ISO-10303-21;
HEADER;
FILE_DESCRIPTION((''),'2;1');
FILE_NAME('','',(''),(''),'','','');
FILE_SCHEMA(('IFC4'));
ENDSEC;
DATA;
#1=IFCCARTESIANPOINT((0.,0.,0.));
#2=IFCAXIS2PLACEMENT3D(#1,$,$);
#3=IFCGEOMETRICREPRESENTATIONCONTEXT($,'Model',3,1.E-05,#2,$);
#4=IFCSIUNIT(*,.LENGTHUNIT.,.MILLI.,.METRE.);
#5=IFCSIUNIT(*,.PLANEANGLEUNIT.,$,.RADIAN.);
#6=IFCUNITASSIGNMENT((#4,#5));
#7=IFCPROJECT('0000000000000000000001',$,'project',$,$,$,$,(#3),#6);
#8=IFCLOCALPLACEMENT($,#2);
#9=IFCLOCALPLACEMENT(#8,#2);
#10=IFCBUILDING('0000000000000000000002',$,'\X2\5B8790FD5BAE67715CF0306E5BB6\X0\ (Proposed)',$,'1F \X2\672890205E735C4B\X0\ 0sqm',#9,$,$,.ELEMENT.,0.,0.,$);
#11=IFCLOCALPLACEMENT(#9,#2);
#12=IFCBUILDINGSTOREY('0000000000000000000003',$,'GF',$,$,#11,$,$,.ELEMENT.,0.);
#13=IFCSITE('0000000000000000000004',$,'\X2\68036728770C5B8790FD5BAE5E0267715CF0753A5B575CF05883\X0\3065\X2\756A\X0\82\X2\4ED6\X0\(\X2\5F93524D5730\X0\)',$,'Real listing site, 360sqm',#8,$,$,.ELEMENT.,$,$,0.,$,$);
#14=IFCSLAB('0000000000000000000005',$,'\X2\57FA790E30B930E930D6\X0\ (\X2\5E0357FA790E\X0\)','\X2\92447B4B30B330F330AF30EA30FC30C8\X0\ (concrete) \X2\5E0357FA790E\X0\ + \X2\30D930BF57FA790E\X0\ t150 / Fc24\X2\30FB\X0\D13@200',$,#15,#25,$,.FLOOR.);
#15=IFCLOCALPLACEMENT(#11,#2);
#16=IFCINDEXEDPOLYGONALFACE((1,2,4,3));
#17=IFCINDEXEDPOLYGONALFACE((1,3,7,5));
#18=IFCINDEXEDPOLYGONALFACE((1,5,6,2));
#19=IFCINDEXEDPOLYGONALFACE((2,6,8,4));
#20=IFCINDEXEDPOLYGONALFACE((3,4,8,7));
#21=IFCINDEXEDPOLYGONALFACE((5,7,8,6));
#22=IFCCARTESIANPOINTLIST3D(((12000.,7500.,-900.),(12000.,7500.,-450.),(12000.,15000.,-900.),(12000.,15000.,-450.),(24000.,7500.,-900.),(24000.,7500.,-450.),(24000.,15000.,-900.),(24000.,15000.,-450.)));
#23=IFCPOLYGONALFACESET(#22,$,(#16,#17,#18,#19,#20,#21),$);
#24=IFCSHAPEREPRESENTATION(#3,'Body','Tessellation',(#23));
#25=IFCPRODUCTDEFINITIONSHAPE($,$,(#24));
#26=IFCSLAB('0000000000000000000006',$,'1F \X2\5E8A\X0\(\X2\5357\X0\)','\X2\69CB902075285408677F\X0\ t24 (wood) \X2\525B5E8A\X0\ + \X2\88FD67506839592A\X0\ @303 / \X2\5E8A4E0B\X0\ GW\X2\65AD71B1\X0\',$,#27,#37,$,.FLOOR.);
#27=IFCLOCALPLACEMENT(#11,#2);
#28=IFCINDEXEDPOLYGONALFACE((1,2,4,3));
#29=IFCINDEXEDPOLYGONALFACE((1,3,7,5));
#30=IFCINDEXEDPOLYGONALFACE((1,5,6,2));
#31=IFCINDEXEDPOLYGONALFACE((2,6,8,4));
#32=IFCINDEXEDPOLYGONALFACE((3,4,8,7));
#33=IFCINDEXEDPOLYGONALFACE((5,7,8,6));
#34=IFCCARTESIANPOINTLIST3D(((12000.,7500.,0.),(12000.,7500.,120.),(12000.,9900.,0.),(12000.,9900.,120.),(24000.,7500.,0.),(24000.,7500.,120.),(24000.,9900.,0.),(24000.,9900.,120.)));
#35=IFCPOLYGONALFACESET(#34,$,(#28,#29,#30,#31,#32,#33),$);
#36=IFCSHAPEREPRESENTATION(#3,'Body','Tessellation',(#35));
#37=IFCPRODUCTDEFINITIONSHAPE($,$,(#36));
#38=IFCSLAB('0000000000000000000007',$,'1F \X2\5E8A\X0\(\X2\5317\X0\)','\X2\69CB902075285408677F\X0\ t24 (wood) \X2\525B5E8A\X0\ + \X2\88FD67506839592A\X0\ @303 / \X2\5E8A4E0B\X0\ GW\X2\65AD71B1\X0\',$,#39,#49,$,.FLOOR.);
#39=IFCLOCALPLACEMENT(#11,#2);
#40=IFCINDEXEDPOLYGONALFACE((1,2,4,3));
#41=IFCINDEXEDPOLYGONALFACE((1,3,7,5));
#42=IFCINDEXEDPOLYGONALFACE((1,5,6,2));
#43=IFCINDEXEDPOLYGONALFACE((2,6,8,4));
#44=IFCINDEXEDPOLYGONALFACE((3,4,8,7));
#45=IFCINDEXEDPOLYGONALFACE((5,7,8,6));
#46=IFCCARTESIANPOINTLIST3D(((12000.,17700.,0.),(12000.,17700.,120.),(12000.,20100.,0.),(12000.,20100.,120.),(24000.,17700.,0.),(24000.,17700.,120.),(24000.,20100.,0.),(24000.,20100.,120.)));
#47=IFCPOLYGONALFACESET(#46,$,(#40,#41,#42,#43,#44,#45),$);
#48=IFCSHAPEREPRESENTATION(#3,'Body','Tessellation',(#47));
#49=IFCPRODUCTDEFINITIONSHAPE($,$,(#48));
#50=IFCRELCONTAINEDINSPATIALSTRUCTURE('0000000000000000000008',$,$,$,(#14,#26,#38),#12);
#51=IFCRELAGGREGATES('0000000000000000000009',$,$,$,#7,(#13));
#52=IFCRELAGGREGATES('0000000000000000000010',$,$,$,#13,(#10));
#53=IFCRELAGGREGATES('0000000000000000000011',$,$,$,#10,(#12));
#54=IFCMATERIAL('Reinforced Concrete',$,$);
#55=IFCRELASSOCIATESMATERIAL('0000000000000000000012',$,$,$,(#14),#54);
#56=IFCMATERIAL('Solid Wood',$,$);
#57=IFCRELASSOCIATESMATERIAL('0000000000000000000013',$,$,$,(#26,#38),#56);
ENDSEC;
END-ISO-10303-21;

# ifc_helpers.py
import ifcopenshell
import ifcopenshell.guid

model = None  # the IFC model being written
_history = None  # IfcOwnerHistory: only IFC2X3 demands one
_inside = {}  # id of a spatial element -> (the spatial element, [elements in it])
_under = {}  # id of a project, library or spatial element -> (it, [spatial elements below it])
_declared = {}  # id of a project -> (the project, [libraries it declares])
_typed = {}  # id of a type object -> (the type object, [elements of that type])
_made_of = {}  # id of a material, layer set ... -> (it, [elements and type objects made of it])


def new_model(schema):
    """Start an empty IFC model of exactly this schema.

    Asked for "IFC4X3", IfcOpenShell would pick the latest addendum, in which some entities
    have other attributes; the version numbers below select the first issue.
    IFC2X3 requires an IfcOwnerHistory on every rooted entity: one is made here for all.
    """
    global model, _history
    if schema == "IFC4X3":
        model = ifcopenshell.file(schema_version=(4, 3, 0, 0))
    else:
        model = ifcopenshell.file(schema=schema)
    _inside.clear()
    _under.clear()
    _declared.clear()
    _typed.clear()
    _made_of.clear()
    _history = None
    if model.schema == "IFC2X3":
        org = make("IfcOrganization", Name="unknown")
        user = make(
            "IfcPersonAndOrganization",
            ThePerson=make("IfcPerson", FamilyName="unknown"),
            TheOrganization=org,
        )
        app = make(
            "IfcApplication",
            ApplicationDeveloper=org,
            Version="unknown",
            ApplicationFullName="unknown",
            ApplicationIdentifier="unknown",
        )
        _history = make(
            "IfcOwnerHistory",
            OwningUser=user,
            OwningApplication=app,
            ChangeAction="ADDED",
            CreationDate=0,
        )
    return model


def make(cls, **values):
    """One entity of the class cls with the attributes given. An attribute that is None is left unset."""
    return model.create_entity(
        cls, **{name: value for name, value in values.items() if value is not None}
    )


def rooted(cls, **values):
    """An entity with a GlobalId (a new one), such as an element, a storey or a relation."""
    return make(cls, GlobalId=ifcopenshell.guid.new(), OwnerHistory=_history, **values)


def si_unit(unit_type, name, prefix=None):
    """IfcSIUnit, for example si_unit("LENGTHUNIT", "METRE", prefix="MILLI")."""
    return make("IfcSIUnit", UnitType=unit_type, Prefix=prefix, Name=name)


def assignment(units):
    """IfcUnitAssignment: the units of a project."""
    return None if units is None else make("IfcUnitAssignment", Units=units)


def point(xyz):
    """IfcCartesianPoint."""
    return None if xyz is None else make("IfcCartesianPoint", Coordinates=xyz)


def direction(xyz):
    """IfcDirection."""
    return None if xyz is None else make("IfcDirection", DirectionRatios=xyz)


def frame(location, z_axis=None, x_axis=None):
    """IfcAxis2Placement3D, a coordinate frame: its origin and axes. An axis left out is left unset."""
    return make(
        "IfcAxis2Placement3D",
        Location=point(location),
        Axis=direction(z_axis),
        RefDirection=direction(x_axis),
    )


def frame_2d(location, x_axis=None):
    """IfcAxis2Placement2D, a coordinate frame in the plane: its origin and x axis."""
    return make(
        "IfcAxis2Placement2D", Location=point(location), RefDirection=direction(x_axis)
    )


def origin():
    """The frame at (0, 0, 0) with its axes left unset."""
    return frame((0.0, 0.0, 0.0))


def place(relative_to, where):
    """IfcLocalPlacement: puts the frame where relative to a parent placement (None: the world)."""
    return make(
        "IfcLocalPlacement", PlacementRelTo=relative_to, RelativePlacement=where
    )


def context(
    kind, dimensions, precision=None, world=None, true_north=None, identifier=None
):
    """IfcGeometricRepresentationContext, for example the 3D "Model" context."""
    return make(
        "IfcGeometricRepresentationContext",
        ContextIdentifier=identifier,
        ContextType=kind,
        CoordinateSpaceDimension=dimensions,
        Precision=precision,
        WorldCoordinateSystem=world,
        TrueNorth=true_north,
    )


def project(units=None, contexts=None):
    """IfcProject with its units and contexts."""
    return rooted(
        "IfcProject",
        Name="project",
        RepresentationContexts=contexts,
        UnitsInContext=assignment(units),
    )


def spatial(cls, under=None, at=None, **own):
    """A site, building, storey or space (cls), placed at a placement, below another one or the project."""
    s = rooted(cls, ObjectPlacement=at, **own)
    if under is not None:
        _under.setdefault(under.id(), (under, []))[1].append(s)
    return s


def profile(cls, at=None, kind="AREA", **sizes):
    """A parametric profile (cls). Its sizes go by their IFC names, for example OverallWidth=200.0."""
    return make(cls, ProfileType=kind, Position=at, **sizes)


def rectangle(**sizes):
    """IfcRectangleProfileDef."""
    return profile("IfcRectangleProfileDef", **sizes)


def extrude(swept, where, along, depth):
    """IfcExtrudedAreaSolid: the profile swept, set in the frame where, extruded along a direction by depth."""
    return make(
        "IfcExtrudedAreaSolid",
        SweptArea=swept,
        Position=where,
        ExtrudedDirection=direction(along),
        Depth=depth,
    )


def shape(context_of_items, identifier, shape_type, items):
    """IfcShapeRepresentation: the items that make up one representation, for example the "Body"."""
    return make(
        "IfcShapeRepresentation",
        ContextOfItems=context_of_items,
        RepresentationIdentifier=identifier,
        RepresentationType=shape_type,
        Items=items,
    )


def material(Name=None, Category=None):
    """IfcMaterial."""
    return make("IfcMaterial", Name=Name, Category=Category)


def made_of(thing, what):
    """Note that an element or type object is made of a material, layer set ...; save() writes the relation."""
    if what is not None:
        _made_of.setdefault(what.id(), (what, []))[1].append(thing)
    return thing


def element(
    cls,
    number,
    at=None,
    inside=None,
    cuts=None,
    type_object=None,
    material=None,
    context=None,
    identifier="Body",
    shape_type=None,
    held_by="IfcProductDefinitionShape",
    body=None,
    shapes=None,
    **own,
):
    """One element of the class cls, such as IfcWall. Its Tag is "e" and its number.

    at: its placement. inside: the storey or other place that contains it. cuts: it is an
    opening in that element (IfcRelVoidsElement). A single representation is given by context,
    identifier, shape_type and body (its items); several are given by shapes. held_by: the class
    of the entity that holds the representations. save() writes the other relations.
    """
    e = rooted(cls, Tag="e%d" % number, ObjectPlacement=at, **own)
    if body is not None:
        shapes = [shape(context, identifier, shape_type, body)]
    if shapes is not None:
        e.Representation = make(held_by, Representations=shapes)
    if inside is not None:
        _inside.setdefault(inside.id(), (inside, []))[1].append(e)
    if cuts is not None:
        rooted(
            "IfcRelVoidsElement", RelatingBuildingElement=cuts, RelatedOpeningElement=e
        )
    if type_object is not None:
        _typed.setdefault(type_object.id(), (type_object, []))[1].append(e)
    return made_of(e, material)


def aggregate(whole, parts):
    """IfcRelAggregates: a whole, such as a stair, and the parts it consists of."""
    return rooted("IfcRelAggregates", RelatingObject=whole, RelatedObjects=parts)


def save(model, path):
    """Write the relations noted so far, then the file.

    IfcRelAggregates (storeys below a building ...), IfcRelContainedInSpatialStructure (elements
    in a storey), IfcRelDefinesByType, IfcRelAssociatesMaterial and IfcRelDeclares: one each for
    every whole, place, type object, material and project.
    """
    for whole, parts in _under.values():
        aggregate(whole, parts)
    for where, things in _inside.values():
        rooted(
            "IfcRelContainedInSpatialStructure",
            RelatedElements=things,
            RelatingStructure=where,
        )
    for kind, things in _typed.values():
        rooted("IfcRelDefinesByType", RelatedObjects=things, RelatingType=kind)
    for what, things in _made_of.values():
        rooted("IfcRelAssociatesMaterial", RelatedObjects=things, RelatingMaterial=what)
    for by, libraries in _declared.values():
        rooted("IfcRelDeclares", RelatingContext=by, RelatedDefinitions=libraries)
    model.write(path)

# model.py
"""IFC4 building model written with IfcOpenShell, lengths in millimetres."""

from ifc_helpers import new_model, si_unit, frame, frame_2d, origin, place, context, project, spatial, rectangle, extrude, material, element, save


model = new_model("IFC4")

# Units and contexts
model_context = context("Model", 3, precision=1e-05, world=origin())
ifc_project = project(units=[si_unit("LENGTHUNIT", "METRE", prefix="MILLI"), si_unit("PLANEANGLEUNIT", "RADIAN")], contexts=[model_context])

# Site, building, storey
site_placement = place(None, origin())
site = spatial("IfcSite", under=ifc_project, at=site_placement, Name="栃木県宇都宮市東峰町字峰境3065番82他(従前地)", ObjectType="Real listing site, 360sqm", CompositionType="ELEMENT", RefElevation=0.0)
building_placement = place(site_placement, origin())
building = spatial("IfcBuilding", under=site, at=building_placement, Name="宇都宮東峰の家 (Proposed)", ObjectType="1F 木造平屋 0sqm", CompositionType="ELEMENT", ElevationOfRefHeight=0.0, ElevationOfTerrain=0.0)
storey_placement = place(building_placement, origin())
storey = spatial("IfcBuildingStorey", under=building, at=storey_placement, Name="GF", CompositionType="ELEMENT", Elevation=0.0)

# Slabs
ifc_material_1 = material(Name="Reinforced Concrete")
slab_1_placement = place(storey_placement, frame((6000.0, 3750.0, -450.0)))
element("IfcSlab", 1, at=slab_1_placement, inside=storey, material=ifc_material_1, Name="基礎スラブ (布基礎)", Description="鉄筋コンクリート (concrete) 布基礎 + ベタ基礎 t150 / Fc24・D13@200", PredefinedType="FLOOR", context=model_context, shape_type="SweptSolid", body=[
    extrude(rectangle(XDim=12000.0, YDim=7500.0, at=frame_2d((6000.0, 3750.0))), frame((6000.0, 3750.0, -450.0)), (0.0, 0.0, 1.0), 450.0),
])
ifc_material_2 = material(Name="Solid Wood")
slab_2_placement = place(storey_placement, frame((6000.0, 3750.0, 0.0)))
element("IfcSlab", 2, at=slab_2_placement, inside=storey, material=ifc_material_2, Name="1F 床(南)", Description="構造用合板 t24 (wood) 剛床 + 製材根太 @303 / 床下 GW断熱", PredefinedType="FLOOR", context=model_context, shape_type="SweptSolid", body=[
    extrude(rectangle(XDim=12000.0, YDim=2400.0, at=frame_2d((6000.0, 1200.0))), frame((6000.0, 3750.0, 0.0)), (0.0, 0.0, 1.0), 120.0),
])
slab_3_placement = place(storey_placement, frame((6000.0, 8850.0, 0.0)))
element("IfcSlab", 3, at=slab_3_placement, inside=storey, material=ifc_material_2, Name="1F 床(北)", Description="構造用合板 t24 (wood) 剛床 + 製材根太 @303 / 床下 GW断熱", PredefinedType="FLOOR", context=model_context, shape_type="SweptSolid", body=[
    extrude(rectangle(XDim=12000.0, YDim=2400.0, at=frame_2d((6000.0, 1200.0))), frame((6000.0, 8850.0, 0.0)), (0.0, 0.0, 1.0), 120.0),
])

save(model, "model.ifc")
